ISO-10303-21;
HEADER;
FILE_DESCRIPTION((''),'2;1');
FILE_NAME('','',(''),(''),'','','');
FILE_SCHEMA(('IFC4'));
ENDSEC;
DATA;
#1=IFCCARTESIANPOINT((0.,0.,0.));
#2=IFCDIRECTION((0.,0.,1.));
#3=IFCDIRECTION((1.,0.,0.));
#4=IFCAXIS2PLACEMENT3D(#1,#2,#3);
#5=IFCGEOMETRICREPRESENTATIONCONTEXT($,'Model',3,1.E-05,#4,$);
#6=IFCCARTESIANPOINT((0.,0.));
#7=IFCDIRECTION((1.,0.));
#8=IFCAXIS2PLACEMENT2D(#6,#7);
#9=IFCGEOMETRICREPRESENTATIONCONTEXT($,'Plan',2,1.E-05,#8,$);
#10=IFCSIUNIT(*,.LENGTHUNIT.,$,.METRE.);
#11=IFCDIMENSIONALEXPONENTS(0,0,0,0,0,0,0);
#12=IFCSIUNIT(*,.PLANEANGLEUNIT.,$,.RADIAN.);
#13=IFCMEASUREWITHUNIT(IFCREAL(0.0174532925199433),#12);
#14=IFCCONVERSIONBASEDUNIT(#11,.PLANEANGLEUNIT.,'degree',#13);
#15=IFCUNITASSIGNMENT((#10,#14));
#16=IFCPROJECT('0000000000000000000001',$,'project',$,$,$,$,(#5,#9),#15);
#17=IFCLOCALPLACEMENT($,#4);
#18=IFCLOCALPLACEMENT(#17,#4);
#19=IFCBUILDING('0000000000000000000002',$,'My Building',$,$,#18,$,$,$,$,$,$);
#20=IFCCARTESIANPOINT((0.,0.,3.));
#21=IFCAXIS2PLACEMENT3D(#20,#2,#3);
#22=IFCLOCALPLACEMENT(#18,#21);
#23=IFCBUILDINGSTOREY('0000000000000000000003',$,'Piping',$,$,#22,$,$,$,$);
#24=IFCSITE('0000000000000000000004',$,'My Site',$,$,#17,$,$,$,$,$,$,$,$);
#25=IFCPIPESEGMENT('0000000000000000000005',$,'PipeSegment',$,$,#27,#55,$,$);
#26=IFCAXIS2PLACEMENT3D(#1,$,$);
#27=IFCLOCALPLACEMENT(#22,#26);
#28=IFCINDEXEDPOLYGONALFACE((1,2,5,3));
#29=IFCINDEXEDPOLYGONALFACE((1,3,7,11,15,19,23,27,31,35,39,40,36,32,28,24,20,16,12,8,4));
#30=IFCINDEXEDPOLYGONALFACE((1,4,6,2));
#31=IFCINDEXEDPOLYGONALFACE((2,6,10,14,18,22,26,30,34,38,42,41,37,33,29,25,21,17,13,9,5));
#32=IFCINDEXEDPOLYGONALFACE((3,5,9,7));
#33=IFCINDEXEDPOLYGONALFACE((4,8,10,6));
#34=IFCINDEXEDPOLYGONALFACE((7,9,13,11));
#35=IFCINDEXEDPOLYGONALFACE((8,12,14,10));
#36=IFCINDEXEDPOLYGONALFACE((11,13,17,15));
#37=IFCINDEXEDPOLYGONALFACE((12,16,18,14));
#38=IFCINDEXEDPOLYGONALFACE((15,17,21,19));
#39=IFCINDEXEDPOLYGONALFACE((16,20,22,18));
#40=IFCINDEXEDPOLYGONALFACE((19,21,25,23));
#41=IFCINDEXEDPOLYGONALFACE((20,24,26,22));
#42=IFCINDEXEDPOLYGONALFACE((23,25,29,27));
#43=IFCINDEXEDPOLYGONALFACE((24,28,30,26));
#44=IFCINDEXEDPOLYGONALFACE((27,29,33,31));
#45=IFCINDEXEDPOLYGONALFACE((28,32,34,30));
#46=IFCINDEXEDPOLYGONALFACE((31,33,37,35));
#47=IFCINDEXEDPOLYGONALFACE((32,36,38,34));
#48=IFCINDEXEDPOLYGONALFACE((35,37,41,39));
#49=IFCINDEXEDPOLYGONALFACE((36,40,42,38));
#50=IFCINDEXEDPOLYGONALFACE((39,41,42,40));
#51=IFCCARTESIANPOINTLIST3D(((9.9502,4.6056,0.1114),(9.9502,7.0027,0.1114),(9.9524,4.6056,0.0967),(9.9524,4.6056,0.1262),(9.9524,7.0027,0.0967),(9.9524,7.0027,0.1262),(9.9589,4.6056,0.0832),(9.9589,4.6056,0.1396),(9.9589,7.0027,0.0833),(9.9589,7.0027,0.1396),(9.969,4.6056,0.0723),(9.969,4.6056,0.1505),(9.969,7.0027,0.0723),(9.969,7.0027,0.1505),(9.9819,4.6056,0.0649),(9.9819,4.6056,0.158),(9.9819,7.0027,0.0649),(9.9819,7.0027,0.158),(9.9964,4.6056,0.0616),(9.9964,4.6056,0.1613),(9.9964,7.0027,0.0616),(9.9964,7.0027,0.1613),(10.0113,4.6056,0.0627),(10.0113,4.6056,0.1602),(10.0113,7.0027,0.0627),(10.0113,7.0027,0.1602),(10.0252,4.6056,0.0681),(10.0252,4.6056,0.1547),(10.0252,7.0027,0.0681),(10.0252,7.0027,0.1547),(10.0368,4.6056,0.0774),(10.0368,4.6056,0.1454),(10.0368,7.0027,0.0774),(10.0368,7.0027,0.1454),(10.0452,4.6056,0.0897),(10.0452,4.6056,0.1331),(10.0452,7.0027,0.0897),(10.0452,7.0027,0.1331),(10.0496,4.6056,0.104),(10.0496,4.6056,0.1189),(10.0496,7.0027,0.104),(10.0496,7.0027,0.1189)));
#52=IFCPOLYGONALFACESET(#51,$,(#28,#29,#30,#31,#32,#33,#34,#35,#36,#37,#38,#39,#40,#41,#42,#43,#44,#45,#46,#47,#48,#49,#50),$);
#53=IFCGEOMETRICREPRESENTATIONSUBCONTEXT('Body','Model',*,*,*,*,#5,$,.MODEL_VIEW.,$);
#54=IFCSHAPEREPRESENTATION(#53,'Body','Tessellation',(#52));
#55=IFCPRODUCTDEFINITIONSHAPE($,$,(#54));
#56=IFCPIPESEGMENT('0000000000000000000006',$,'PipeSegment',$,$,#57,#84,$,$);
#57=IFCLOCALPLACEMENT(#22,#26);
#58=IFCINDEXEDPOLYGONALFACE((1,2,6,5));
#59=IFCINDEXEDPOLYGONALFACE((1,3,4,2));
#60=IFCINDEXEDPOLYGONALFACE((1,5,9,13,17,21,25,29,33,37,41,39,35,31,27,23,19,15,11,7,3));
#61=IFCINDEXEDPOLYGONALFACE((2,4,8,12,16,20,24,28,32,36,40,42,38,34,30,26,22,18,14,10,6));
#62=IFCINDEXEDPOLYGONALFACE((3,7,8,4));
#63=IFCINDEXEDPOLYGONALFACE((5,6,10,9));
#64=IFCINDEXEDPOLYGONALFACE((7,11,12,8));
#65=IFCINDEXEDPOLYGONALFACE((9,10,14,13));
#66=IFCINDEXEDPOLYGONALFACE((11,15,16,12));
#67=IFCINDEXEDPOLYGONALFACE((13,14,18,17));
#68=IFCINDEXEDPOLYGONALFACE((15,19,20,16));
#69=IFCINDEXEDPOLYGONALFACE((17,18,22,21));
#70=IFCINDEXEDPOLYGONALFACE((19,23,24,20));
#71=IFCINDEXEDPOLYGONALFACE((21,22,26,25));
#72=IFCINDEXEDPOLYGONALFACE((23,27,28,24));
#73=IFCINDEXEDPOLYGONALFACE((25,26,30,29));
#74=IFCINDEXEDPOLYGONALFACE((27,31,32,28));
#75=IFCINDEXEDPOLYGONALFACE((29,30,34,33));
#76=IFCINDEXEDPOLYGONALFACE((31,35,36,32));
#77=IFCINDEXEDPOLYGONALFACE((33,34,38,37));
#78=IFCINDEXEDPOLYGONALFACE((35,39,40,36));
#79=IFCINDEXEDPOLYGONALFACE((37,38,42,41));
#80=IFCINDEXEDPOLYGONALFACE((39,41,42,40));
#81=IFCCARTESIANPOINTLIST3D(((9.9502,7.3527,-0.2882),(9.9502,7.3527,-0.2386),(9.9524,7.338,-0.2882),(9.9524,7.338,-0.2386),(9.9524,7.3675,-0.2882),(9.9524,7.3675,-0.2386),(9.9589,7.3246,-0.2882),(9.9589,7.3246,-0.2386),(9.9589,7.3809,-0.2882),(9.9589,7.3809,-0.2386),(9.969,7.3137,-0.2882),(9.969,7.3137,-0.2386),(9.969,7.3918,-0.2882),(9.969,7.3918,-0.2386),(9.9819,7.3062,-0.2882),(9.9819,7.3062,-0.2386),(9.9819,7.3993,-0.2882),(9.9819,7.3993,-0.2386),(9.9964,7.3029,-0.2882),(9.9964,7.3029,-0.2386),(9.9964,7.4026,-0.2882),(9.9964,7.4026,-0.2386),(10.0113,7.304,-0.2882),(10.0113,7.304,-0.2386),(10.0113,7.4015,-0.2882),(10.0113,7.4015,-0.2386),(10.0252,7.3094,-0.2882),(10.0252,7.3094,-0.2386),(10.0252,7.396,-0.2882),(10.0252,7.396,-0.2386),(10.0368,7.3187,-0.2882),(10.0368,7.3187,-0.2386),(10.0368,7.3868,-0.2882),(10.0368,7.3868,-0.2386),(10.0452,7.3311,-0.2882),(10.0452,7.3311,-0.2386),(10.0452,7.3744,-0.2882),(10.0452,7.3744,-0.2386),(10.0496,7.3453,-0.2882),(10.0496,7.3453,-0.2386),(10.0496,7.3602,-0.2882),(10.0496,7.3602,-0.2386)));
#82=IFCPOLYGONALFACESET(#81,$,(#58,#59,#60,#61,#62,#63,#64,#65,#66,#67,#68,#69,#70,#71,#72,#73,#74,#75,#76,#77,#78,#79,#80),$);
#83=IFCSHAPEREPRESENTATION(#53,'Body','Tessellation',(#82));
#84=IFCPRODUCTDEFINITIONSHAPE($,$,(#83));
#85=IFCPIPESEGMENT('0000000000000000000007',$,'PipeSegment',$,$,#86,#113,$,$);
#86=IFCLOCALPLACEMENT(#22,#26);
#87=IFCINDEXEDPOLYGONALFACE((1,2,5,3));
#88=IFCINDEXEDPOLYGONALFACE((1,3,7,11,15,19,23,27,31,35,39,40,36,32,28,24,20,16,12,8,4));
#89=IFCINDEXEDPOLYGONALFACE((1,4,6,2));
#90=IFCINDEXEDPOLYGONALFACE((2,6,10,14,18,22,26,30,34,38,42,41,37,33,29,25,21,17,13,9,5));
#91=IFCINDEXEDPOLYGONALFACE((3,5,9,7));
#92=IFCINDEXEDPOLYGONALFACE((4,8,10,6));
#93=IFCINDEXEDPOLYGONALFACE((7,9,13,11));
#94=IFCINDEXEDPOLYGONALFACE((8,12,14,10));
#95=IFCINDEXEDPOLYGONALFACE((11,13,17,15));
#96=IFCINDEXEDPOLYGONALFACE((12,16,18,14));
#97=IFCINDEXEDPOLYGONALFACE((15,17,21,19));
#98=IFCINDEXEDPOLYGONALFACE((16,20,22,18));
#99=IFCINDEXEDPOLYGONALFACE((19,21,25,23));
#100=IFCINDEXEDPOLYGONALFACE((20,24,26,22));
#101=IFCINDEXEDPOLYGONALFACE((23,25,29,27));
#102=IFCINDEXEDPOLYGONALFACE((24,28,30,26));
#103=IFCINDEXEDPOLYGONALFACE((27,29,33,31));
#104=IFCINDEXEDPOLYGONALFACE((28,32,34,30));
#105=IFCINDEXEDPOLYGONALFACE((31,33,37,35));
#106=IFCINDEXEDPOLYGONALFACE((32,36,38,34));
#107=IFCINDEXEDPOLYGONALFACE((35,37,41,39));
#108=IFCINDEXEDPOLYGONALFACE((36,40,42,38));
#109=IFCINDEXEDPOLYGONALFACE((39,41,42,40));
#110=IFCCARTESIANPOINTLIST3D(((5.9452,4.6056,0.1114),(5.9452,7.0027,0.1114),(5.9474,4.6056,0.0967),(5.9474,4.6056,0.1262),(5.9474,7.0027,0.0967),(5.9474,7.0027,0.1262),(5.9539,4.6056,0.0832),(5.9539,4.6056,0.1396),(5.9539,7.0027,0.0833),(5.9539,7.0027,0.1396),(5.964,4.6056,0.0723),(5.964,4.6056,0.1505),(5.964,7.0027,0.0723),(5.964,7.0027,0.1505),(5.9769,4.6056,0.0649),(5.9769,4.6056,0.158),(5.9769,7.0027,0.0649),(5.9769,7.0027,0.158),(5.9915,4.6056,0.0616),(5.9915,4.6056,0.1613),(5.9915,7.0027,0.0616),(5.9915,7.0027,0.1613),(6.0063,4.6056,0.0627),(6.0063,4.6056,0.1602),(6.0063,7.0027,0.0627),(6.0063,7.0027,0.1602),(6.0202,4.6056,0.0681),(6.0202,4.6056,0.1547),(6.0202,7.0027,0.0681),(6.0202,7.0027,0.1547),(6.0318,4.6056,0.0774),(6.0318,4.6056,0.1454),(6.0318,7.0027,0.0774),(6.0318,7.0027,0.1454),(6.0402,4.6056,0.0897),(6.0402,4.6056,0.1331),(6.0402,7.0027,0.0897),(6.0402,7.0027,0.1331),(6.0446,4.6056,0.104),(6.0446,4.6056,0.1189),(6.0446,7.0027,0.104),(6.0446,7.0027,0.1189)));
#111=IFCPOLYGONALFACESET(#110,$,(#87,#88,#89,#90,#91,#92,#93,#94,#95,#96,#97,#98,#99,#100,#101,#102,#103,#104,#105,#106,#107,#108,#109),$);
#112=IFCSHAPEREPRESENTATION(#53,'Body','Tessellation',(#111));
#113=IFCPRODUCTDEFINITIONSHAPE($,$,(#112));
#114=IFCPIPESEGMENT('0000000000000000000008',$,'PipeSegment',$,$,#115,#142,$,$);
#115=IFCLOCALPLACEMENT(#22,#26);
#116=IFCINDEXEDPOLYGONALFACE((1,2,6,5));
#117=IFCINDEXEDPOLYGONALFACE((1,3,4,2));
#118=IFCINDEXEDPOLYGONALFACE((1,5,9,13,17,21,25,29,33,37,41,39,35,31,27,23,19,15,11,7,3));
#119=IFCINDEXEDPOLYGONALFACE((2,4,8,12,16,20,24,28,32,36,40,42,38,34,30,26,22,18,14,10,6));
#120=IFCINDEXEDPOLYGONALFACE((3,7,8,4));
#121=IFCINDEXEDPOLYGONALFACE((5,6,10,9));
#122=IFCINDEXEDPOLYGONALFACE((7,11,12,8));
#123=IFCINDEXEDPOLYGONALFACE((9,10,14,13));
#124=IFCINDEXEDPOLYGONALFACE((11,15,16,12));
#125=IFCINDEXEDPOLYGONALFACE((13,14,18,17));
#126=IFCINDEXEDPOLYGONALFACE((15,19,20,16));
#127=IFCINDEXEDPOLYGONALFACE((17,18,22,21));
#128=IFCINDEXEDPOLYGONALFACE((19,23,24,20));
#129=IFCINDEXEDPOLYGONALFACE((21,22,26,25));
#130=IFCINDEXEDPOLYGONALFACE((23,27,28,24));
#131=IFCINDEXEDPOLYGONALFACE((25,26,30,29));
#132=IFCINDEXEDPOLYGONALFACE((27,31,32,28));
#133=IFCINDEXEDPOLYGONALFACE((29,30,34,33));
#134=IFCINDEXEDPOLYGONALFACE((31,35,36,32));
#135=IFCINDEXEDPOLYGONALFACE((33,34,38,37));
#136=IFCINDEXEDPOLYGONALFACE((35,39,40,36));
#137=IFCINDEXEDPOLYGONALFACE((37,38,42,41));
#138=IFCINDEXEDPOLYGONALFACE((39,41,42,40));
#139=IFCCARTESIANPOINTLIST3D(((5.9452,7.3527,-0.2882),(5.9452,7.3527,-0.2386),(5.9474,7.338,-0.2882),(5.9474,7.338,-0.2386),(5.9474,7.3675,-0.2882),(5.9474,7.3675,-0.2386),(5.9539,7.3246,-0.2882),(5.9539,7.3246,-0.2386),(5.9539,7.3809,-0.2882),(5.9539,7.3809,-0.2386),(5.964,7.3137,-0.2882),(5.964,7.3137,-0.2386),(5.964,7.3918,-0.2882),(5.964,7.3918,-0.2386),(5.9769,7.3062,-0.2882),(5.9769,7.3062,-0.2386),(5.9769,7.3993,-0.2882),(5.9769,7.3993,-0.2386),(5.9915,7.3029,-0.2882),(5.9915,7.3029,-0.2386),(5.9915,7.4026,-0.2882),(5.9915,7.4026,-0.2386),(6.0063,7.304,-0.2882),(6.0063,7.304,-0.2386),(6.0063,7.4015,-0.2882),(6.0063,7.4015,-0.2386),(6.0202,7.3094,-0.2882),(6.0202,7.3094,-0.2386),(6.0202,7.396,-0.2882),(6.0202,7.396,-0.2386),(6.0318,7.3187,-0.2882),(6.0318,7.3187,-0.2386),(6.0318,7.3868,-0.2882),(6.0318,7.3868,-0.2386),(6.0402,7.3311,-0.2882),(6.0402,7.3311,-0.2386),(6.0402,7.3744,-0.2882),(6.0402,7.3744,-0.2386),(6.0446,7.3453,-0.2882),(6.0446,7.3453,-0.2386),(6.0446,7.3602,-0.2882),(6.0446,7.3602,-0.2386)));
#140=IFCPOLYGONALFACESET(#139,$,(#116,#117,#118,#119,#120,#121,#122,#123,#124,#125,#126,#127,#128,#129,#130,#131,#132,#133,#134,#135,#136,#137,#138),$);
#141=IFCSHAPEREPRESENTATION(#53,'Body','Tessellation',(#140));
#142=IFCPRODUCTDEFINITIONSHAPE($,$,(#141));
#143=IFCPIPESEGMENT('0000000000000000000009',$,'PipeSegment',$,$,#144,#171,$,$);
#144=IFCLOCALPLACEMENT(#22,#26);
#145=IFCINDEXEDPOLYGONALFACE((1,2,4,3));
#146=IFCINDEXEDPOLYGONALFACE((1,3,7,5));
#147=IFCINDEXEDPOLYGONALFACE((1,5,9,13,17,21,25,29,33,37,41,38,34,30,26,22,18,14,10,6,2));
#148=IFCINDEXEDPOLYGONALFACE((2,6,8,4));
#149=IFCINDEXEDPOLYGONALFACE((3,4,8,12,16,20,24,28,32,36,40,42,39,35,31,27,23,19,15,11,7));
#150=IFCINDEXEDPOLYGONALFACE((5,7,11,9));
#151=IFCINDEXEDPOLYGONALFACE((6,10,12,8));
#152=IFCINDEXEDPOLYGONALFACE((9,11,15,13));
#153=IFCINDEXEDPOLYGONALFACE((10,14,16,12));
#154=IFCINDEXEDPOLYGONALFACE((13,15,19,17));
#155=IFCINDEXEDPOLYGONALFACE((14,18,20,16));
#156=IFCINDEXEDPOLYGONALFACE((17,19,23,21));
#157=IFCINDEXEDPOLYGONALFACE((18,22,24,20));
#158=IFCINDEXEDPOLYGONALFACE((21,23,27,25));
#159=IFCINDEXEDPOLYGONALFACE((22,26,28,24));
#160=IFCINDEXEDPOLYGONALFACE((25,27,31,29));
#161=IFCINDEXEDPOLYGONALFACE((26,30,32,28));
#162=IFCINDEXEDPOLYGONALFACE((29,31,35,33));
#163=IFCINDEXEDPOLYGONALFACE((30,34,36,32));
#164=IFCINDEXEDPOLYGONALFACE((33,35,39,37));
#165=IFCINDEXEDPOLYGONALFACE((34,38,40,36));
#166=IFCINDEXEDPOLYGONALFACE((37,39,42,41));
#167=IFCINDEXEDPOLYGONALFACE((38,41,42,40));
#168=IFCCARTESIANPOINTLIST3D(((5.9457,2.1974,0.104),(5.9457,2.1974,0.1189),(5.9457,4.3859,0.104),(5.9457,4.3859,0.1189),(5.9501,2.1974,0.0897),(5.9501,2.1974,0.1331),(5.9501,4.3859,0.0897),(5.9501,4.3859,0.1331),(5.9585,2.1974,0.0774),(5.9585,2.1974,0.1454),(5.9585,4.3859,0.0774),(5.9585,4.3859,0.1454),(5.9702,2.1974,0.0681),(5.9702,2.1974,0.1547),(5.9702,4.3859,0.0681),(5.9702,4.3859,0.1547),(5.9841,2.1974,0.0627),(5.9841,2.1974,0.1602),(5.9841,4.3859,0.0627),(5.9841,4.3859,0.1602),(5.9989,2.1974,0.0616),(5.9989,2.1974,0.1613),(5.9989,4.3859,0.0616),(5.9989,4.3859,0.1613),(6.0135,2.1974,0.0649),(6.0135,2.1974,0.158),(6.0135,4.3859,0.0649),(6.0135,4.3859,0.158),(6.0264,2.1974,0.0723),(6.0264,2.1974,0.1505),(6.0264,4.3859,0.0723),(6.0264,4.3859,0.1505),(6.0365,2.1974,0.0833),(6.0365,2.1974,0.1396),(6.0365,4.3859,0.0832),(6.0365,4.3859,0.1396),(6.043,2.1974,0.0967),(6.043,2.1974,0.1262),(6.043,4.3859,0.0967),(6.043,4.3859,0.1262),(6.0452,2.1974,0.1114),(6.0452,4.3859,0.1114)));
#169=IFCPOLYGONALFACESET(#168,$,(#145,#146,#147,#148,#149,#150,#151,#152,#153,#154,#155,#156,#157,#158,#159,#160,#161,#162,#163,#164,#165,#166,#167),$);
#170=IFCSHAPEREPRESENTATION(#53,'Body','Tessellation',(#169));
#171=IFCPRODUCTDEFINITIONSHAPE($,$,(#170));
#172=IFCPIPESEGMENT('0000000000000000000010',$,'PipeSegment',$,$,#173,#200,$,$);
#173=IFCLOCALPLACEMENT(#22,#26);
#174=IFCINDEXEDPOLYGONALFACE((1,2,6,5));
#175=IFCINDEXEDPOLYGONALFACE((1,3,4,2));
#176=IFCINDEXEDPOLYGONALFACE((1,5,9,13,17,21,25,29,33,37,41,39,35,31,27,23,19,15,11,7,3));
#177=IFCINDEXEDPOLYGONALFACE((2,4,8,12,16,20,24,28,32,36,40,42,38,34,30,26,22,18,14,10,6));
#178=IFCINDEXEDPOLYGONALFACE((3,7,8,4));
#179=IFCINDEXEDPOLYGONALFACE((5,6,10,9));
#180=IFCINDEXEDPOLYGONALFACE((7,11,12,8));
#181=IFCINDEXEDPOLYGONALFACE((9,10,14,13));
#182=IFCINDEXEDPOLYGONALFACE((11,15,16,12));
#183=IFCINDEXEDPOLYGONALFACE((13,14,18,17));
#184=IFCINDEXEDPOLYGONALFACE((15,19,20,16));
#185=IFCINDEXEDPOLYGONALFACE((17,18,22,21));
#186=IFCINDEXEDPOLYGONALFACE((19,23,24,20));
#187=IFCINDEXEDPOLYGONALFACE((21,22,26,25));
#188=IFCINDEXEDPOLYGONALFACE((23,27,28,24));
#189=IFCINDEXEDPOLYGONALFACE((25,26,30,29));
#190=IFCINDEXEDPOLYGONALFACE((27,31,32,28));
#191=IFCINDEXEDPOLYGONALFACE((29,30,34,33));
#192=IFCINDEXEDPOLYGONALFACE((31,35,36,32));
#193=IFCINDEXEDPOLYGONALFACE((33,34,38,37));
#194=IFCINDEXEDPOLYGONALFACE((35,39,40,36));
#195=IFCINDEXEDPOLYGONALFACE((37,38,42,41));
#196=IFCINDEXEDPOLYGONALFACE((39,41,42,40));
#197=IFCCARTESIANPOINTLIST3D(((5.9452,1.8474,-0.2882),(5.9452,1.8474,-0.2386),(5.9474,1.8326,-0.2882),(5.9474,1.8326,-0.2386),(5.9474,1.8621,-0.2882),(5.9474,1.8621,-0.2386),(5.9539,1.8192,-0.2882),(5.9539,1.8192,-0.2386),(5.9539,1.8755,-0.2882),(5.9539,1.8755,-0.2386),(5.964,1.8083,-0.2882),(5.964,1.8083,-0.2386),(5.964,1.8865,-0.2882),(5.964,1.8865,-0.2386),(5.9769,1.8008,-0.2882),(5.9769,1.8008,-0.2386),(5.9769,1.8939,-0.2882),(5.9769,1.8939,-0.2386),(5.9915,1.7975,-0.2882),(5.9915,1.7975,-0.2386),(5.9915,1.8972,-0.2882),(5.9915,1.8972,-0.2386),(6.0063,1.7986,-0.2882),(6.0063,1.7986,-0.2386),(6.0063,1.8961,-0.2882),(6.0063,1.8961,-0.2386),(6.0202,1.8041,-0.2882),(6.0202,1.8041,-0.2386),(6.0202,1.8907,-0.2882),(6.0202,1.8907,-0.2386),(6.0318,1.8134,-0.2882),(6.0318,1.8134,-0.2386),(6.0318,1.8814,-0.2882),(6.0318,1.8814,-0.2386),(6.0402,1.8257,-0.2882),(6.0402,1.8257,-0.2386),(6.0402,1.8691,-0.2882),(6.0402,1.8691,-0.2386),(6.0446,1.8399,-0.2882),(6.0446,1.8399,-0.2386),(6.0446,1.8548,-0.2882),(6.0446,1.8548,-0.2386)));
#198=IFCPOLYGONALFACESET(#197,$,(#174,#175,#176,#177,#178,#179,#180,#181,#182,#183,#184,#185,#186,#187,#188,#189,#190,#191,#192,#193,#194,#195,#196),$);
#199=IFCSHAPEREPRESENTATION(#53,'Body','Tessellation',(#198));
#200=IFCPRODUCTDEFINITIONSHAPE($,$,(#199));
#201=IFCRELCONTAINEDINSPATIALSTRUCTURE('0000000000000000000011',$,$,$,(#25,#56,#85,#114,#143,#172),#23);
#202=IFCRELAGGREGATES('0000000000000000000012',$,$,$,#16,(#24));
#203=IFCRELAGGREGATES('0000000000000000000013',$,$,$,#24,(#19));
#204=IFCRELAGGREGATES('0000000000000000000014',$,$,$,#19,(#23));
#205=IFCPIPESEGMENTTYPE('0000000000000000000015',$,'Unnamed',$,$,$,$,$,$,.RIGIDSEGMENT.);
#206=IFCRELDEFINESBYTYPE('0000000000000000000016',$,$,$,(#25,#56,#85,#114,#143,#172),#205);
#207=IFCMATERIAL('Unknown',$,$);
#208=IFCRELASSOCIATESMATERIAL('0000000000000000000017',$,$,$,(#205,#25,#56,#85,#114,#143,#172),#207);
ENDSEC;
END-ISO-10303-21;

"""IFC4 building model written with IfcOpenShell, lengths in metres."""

from ifc_helpers import new_model, entity, si_unit, converted_unit, frame, origin_with_axes, origin_2d_with_axis, place, context, subcontext, project, spatial, circle, extrude, material, material_profile, profile_set, profile_usage, type_object, element, save


model = new_model("IFC4")

# Units and contexts
model_context = context("Model", 3, precision=1e-05, world=origin_with_axes())
plan_context = context("Plan", 2, precision=1e-05, world=origin_2d_with_axis())
body_context = subcontext(model_context, "Body", "Model", "MODEL_VIEW")
ifc_project = project(units=[si_unit("LENGTHUNIT", "METRE"), converted_unit("PLANEANGLEUNIT", "degree", entity("IfcReal", 0.0174532925199433), si_unit("PLANEANGLEUNIT", "RADIAN"), dimensions=[0, 0, 0, 0, 0, 0, 0])], contexts=[model_context, plan_context])

# Site, building, storey
site_placement = place(None, origin_with_axes())
site = spatial("IfcSite", under=ifc_project, at=site_placement, Name="My Site")
building_placement = place(site_placement, origin_with_axes())
building = spatial("IfcBuilding", under=site, at=building_placement, Name="My Building")
storey_placement = place(building_placement, frame((0.0, 0.0, 3.0), z_axis=(0.0, 0.0, 1.0), x_axis=(1.0, 0.0, 0.0)))
storey = spatial("IfcBuildingStorey", under=building, at=storey_placement, Name="Piping")

# Pipe segments
ifc_material = material(Name="Unknown")
ifc_material_profile_1 = material_profile(ifc_material, circle(Radius=0.05))
ifc_profile_set_1 = profile_set([ifc_material_profile_1])
ifc_profile_usage_1 = profile_usage(ifc_profile_set_1, cardinal=16)
pipe_segment_type = type_object("IfcPipeSegmentType", Name="Unnamed", PredefinedType="RIGIDSEGMENT", material=ifc_profile_set_1)
pipe_segment_1_placement = place(storey_placement, frame((10.0002, 4.6056, 0.1114), z_axis=(0.0, 1.0, 0.0), x_axis=(-1.0, 0.0, 0.0)))
element("IfcPipeSegment", 1, at=pipe_segment_1_placement, inside=storey, type_object=pipe_segment_type, material=ifc_profile_usage_1, Name="PipeSegment", context=body_context, shape_type="SweptSolid", body=[
    extrude(circle(Radius=0.05), origin_with_axes(), (0.0, 0.0, 1.0), 2.3972),
])
ifc_profile_usage_2 = profile_usage(ifc_profile_set_1, cardinal=16)
pipe_segment_2_placement = place(storey_placement, frame((10.0002, 7.3527, -0.2386), z_axis=(0.0, 0.0, -1.0), x_axis=(-1.0, 0.0, 0.0)))
element("IfcPipeSegment", 2, at=pipe_segment_2_placement, inside=storey, type_object=pipe_segment_type, material=ifc_profile_usage_2, Name="PipeSegment", context=body_context, shape_type="SweptSolid", body=[
    extrude(circle(Radius=0.05), origin_with_axes(), (0.0, 0.0, 1.0), 0.0496),
])
ifc_profile_usage_3 = profile_usage(ifc_profile_set_1, cardinal=16)
pipe_segment_3_placement = place(storey_placement, frame((5.9952, 4.6056, 0.1114), z_axis=(0.0, 1.0, 0.0), x_axis=(-1.0, 0.0, 0.0)))
element("IfcPipeSegment", 3, at=pipe_segment_3_placement, inside=storey, type_object=pipe_segment_type, material=ifc_profile_usage_3, Name="PipeSegment", context=body_context, shape_type="SweptSolid", body=[
    extrude(circle(Radius=0.05), origin_with_axes(), (0.0, 0.0, 1.0), 2.3972),
])
ifc_profile_usage_4 = profile_usage(ifc_profile_set_1, cardinal=16)
pipe_segment_4_placement = place(storey_placement, frame((5.9952, 7.3527, -0.2386), z_axis=(0.0, 0.0, -1.0), x_axis=(-1.0, 0.0, 0.0)))
element("IfcPipeSegment", 4, at=pipe_segment_4_placement, inside=storey, type_object=pipe_segment_type, material=ifc_profile_usage_4, Name="PipeSegment", context=body_context, shape_type="SweptSolid", body=[
    extrude(circle(Radius=0.05), origin_with_axes(), (0.0, 0.0, 1.0), 0.0496),
])
ifc_profile_usage_5 = profile_usage(ifc_profile_set_1, cardinal=16)
pipe_segment_5_placement = place(storey_placement, frame((5.9952, 4.3859, 0.1114), z_axis=(0.0, -1.0, 0.0), x_axis=(1.0, 0.0, 0.0)))
element("IfcPipeSegment", 5, at=pipe_segment_5_placement, inside=storey, type_object=pipe_segment_type, material=ifc_profile_usage_5, Name="PipeSegment", context=body_context, shape_type="SweptSolid", body=[
    extrude(circle(Radius=0.05), origin_with_axes(), (0.0, 0.0, 1.0), 2.1885),
])
ifc_profile_usage_6 = profile_usage(ifc_profile_set_1, cardinal=16)
pipe_segment_6_placement = place(storey_placement, frame((5.9952, 1.8474, -0.2386), z_axis=(0.0, 0.0, -1.0), x_axis=(-1.0, 0.0, 0.0)))
element("IfcPipeSegment", 6, at=pipe_segment_6_placement, inside=storey, type_object=pipe_segment_type, material=ifc_profile_usage_6, Name="PipeSegment", context=body_context, shape_type="SweptSolid", body=[
    extrude(circle(Radius=0.05), origin_with_axes(), (0.0, 0.0, 1.0), 0.0496),
])

save(model, "model.ifc")
